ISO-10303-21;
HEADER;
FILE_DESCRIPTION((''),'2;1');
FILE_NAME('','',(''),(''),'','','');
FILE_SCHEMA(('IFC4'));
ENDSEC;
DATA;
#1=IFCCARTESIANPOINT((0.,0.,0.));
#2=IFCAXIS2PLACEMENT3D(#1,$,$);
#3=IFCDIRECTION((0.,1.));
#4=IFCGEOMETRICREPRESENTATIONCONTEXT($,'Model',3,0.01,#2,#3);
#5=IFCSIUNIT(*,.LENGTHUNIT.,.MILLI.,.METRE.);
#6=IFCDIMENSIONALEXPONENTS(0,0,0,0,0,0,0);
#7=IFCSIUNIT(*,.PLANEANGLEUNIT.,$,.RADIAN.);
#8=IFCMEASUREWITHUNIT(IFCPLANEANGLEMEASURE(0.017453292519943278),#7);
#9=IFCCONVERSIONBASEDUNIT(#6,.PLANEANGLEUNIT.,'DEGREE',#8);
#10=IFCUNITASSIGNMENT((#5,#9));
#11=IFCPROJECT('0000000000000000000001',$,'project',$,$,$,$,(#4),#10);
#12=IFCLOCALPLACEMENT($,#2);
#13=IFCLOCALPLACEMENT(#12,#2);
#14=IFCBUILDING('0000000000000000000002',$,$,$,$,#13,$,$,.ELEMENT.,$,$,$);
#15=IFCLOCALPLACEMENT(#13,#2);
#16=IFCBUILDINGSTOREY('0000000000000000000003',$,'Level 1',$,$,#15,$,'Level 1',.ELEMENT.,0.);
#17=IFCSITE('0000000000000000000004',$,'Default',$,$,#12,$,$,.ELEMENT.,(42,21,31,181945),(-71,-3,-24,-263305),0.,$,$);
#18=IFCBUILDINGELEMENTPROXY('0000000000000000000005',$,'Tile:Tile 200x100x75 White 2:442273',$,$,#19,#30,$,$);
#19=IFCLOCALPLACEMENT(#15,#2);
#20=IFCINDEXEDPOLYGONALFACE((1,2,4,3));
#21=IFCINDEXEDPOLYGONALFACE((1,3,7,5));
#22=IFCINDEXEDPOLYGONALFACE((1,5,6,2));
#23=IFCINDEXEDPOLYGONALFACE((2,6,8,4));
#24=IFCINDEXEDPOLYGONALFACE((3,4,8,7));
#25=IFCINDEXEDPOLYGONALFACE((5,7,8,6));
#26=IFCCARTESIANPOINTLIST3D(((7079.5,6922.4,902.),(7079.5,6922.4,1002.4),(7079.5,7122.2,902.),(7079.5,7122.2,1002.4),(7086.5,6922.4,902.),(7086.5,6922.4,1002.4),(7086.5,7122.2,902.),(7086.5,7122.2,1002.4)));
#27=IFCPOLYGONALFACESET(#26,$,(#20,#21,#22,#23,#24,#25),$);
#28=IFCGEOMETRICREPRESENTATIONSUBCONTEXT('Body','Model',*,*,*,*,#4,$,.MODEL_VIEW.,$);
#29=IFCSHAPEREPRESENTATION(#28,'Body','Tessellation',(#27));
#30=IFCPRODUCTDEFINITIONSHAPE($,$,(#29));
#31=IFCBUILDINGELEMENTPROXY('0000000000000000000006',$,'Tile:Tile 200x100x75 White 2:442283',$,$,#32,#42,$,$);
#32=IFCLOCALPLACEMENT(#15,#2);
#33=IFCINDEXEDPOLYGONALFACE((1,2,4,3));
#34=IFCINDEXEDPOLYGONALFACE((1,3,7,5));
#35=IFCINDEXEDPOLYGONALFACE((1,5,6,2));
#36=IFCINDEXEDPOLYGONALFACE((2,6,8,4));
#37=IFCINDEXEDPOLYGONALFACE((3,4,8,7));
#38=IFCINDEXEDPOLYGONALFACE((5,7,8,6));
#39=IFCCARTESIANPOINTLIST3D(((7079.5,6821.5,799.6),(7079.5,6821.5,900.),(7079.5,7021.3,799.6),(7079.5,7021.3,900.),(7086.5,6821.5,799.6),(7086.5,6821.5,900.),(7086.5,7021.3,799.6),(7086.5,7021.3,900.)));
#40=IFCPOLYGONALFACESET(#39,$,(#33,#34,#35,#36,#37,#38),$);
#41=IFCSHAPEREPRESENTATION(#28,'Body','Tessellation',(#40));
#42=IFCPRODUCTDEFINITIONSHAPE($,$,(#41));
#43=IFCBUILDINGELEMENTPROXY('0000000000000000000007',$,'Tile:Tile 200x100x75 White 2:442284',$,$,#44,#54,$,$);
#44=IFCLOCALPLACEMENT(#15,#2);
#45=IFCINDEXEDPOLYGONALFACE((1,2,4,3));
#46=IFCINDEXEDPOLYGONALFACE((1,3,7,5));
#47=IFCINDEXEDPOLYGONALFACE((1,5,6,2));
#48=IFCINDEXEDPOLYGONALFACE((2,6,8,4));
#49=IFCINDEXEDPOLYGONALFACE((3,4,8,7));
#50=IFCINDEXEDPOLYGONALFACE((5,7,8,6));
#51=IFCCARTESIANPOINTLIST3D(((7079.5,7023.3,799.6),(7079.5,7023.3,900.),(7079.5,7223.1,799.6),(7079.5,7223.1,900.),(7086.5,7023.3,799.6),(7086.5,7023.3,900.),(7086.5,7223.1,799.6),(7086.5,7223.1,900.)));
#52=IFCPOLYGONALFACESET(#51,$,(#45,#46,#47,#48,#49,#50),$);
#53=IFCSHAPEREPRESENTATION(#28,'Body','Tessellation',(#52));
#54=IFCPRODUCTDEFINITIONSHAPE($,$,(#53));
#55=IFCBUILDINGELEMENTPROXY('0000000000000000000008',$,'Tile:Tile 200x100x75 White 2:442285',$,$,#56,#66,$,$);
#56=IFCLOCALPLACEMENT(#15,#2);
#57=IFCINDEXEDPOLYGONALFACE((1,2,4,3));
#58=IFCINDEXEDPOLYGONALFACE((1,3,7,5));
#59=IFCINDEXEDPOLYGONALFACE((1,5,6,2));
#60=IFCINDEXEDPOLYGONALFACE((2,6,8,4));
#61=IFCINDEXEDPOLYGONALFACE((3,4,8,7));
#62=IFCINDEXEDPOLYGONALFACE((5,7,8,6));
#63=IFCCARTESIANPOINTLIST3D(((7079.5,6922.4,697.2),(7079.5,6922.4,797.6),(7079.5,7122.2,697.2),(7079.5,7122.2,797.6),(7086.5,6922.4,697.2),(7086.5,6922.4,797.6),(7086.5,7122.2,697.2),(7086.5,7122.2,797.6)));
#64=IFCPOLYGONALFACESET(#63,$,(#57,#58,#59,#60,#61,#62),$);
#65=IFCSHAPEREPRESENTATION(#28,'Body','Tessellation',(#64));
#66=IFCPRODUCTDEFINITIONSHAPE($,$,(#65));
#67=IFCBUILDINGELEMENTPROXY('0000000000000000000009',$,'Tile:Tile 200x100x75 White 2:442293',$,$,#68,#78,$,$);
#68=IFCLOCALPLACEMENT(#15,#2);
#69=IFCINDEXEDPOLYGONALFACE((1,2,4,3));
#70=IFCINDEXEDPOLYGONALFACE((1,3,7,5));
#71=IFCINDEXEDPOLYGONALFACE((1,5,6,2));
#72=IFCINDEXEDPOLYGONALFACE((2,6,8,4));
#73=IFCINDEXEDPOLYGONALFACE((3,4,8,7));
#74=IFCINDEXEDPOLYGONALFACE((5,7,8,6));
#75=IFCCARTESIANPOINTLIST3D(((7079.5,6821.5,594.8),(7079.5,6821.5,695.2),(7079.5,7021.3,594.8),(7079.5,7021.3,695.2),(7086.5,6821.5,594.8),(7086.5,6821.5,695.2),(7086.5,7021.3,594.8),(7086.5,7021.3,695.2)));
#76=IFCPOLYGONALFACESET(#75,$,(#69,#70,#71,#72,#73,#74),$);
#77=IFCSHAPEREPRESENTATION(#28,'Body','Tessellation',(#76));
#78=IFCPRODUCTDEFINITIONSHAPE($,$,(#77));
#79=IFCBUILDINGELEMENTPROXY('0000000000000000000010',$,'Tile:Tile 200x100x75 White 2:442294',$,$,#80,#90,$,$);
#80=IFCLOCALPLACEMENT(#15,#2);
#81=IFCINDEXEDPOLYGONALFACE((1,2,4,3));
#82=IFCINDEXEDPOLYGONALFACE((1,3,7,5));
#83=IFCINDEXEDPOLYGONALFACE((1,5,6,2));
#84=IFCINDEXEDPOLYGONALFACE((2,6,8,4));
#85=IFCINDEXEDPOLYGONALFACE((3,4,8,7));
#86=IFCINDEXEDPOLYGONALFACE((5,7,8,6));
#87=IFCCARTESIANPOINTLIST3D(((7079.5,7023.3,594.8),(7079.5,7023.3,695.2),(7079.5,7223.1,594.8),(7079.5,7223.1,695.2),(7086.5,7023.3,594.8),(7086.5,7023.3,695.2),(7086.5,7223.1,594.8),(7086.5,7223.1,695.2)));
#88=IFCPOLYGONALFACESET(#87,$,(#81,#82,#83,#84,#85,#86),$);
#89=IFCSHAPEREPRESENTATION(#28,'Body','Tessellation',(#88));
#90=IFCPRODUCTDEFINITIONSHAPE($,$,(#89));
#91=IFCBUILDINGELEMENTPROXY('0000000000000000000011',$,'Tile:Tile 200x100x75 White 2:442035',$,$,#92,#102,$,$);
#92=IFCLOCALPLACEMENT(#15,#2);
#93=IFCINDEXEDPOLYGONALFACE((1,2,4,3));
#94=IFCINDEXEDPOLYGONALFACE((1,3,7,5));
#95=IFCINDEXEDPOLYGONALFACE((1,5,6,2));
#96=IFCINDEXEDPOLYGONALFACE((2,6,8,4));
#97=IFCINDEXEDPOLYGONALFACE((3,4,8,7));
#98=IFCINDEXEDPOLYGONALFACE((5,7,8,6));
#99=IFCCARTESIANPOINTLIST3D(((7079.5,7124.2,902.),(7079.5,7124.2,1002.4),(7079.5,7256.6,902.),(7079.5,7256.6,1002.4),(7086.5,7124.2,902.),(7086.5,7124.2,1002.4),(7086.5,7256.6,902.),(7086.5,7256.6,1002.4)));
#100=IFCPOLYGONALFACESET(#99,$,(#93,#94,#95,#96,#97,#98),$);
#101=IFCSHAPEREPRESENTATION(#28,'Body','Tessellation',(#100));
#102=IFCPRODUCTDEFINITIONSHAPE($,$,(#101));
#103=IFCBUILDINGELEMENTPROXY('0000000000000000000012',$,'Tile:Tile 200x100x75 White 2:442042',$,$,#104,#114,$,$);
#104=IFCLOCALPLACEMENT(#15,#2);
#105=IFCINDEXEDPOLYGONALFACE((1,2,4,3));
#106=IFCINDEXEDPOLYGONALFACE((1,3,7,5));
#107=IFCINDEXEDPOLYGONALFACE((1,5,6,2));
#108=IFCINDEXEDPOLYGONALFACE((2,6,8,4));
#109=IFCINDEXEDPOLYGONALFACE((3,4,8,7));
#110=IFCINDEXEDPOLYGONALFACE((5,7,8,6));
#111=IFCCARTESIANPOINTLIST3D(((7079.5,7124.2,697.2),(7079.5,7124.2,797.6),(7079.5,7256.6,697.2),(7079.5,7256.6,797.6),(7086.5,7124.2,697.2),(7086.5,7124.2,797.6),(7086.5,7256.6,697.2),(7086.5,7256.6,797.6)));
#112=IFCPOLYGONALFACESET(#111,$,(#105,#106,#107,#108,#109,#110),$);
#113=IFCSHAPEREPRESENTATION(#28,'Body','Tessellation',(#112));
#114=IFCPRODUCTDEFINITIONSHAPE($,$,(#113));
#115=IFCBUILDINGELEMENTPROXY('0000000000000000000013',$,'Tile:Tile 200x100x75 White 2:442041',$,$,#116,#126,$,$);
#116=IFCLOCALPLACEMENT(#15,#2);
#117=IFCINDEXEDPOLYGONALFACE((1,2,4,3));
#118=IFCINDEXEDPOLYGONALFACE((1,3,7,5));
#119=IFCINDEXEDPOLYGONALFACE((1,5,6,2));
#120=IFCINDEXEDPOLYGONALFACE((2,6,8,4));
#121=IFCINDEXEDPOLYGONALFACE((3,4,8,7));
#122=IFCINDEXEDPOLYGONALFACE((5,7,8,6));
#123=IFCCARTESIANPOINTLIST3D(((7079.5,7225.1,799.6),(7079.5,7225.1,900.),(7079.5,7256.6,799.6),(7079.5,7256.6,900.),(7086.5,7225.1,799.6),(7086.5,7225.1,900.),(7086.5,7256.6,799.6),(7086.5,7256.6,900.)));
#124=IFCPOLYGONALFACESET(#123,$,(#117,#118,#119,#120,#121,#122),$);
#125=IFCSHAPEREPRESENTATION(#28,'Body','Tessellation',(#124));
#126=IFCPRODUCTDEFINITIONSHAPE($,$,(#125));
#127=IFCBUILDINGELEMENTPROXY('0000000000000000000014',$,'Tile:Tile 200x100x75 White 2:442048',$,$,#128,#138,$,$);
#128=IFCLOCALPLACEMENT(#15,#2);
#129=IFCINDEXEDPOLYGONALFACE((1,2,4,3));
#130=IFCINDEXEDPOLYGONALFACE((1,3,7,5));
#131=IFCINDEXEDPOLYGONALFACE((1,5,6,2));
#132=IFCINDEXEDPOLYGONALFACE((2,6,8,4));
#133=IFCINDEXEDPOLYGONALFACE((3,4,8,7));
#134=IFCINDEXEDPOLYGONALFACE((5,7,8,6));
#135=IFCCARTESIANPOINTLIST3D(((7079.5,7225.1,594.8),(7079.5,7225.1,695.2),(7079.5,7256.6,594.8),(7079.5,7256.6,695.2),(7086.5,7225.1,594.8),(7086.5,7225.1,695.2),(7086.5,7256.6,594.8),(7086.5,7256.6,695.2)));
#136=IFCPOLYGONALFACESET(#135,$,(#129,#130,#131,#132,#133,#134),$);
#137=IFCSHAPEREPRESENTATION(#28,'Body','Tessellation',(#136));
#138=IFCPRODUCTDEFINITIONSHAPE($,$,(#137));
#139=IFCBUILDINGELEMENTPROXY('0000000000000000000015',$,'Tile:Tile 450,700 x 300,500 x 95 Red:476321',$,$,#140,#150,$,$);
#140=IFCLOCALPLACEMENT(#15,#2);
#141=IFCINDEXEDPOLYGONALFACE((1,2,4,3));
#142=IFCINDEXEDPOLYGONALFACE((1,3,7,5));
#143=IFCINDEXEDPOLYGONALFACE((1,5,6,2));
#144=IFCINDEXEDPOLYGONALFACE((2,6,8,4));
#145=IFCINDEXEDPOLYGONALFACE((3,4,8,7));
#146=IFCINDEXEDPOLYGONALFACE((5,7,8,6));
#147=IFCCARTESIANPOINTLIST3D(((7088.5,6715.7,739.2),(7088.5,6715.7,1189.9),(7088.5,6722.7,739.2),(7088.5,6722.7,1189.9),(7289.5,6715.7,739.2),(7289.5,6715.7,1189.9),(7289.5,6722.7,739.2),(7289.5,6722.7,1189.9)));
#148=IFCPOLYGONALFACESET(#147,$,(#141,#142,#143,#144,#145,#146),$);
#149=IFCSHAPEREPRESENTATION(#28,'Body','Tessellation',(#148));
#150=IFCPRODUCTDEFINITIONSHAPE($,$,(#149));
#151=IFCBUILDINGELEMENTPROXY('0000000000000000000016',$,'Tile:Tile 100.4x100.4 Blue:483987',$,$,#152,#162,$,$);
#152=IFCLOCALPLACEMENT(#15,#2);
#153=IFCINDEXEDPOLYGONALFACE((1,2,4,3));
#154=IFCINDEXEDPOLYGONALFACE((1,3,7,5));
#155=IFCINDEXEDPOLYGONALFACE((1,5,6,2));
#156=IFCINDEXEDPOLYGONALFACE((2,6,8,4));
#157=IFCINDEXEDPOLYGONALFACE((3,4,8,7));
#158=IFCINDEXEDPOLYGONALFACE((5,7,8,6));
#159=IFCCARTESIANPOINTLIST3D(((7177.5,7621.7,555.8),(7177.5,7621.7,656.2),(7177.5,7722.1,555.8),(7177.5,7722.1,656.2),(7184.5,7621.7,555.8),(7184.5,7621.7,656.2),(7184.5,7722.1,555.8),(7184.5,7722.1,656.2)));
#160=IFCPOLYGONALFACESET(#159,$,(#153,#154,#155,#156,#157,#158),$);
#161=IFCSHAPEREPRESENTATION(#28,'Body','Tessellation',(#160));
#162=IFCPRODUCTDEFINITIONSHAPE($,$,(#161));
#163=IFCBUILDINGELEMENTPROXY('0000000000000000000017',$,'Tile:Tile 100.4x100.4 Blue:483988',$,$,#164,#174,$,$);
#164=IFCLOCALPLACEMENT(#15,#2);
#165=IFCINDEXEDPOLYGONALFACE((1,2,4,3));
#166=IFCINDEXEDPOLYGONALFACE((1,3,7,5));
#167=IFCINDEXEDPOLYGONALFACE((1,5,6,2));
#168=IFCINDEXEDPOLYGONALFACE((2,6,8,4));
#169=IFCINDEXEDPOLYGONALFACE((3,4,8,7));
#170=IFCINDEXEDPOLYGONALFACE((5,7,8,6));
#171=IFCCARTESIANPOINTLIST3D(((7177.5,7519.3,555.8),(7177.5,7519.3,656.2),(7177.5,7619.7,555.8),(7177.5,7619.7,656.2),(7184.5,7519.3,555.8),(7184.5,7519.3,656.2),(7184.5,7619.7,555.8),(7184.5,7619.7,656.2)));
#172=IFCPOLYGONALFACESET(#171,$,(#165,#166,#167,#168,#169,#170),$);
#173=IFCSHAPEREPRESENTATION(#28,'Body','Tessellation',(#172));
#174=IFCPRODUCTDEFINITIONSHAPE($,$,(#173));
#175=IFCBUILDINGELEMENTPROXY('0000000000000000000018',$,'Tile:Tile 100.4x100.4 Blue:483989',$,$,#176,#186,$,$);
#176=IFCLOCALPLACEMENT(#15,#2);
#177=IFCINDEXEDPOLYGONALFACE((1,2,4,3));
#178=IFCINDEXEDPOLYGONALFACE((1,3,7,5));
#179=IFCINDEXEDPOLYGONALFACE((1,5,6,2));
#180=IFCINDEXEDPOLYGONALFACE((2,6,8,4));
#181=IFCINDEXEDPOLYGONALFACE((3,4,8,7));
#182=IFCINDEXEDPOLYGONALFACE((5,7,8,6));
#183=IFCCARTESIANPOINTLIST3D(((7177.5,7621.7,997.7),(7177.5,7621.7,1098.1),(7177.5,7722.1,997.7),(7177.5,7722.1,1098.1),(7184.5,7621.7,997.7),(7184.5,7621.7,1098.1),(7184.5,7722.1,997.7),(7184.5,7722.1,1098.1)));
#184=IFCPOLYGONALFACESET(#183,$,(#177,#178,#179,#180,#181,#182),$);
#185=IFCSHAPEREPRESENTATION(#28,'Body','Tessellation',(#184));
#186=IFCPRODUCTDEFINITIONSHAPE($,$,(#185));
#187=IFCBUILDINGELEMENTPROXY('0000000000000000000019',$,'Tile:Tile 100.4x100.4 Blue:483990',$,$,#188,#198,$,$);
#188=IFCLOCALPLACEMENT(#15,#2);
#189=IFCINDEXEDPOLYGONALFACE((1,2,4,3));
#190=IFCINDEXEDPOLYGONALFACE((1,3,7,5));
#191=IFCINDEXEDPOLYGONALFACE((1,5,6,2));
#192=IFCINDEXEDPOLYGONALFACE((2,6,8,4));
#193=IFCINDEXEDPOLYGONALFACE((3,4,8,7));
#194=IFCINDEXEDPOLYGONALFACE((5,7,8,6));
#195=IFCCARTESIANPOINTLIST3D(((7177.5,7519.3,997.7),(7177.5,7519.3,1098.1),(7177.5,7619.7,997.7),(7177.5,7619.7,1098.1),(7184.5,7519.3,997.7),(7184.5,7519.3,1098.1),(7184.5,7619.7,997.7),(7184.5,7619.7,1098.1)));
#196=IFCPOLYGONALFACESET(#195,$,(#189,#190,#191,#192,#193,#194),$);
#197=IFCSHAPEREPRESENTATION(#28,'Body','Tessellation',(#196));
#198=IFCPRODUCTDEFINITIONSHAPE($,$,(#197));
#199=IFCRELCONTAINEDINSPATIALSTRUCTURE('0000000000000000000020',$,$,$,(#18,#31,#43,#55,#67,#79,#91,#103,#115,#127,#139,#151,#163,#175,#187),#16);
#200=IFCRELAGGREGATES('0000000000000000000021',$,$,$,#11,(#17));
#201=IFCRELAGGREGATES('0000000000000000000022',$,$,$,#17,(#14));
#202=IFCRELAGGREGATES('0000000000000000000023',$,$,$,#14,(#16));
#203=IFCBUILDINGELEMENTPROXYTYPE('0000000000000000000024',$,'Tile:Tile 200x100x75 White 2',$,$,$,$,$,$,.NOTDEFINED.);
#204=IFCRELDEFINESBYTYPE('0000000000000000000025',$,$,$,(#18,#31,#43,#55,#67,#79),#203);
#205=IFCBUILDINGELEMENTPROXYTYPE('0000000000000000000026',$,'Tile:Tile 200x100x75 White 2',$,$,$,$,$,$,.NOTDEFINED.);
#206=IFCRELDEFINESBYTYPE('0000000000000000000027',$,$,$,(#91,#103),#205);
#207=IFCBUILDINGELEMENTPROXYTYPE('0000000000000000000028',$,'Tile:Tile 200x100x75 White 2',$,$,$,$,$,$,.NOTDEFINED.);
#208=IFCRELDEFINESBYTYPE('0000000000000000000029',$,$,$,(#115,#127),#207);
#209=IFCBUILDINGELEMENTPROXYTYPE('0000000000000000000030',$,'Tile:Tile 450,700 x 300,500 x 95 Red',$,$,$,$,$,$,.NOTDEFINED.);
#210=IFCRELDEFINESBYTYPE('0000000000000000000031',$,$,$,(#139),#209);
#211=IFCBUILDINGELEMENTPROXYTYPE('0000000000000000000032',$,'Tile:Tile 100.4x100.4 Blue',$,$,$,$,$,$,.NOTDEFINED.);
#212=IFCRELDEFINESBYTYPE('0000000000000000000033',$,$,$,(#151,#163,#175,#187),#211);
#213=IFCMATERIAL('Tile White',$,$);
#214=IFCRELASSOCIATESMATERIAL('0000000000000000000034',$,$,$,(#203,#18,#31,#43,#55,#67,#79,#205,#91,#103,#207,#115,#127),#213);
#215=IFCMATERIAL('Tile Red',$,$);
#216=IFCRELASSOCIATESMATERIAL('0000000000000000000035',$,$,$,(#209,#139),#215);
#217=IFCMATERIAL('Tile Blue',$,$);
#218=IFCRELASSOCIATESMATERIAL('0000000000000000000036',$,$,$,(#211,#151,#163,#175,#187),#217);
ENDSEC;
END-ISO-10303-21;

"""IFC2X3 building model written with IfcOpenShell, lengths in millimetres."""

from ifc_helpers import new_model, entity, si_unit, converted_unit, direction, frame, frame_2d, origin, origin_2d_with_axis, place, context, subcontext, project, spatial, rectangle, extrude, source, transform, mapped, material, type_object, type_shapes, element, save


model = new_model("IFC2X3")

# Units and contexts
model_context = context("Model", 3, precision=0.01, world=origin(), true_north=direction((0.0, 1.0)))
body_context = subcontext(model_context, "Body", "Model", "MODEL_VIEW")
ifc_project = project(units=[si_unit("LENGTHUNIT", "METRE", prefix="MILLI"), converted_unit("PLANEANGLEUNIT", "DEGREE", entity("IfcPlaneAngleMeasure", 0.017453292519943278), si_unit("PLANEANGLEUNIT", "RADIAN"), dimensions=[0, 0, 0, 0, 0, 0, 0])], contexts=[model_context])

# Site, building, storey
site_placement = place(None, origin())
site = spatial("IfcSite", under=ifc_project, at=site_placement, Name="Default", CompositionType="ELEMENT", RefLatitude=(42, 21, 31, 181945), RefLongitude=(-71, -3, -24, -263305), RefElevation=0.0)
building_placement = place(site_placement, origin())
building = spatial("IfcBuilding", under=site, at=building_placement, CompositionType="ELEMENT")
storey_placement = place(building_placement, origin())
storey = spatial("IfcBuildingStorey", under=building, at=storey_placement, Name="Level 1", LongName="Level 1", CompositionType="ELEMENT", Elevation=0.0)

# Building element proxies
ifc_material_1 = material(Name="Tile White")
building_element_proxy_type_1 = type_object("IfcBuildingElementProxyType", Name="Tile:Tile 200x100x75 White 2", PredefinedType="NOTDEFINED", material=ifc_material_1)
shared_shape_1 = source(origin(), body_context, "Body", "SweptSolid", [
    extrude(rectangle(XDim=199.8, YDim=100.4, at=frame_2d((0.0, 0.0), x_axis=(1.0, 0.0))), frame((-50.2, -99.9, 0.0), z_axis=(0.0, 0.0, 1.0), x_axis=(0.0, -1.0, 0.0)), (0.0, 0.0, 1.0), 7.0),
])
type_shapes(building_element_proxy_type_1, [shared_shape_1])
for number, where, z_axis, x_axis, name in (
    (1, (7086.5, 7122.2, 1002.4), (-1.0, 0.0, 0.0), (0.0, 0.0, 1.0), "Tile:Tile 200x100x75 White 2:442273"),
    (2, (7086.5, 7021.3, 900.0), (-1.0, 0.0, 0.0), (0.0, 0.0, 1.0), "Tile:Tile 200x100x75 White 2:442283"),
    (3, (7086.5, 7223.1, 900.0), (-1.0, 0.0, 0.0), (0.0, 0.0, 1.0), "Tile:Tile 200x100x75 White 2:442284"),
    (4, (7086.5, 7122.2, 797.6), (-1.0, 0.0, 0.0), (0.0, 0.0, 1.0), "Tile:Tile 200x100x75 White 2:442285"),
    (5, (7086.5, 7021.3, 695.2), (-1.0, 0.0, 0.0), (0.0, 0.0, 1.0), "Tile:Tile 200x100x75 White 2:442293"),
    (6, (7086.5, 7223.1, 695.2), (-1.0, 0.0, 0.0), (0.0, 0.0, 1.0), "Tile:Tile 200x100x75 White 2:442294"),
):
    element("IfcBuildingElementProxy", number, at=place(storey_placement, frame(where, z_axis=z_axis, x_axis=x_axis)), inside=storey, type_object=building_element_proxy_type_1, material=ifc_material_1, Name=name, context=body_context, shape_type="MappedRepresentation", body=[
        mapped(shared_shape_1, transform((0.0, 0.0, 0.0), scale=1.0)),
    ])
building_element_proxy_type_2 = type_object("IfcBuildingElementProxyType", Name="Tile:Tile 200x100x75 White 2", PredefinedType="NOTDEFINED", material=ifc_material_1)
shared_shape_2 = source(origin(), body_context, "Body", "SweptSolid", [
    extrude(rectangle(XDim=100.4, YDim=132.4, at=frame_2d((0.0, 0.0), x_axis=(1.0, 0.0))), frame((-50.2, 66.2, 0.0)), (0.0, 0.0, 1.0), 7.0),
])
type_shapes(building_element_proxy_type_2, [shared_shape_2])
for number, where, z_axis, x_axis, name in (
    (7, (7086.5, 7124.2, 1002.4), (-1.0, 0.0, 0.0), (0.0, 0.0, 1.0), "Tile:Tile 200x100x75 White 2:442035"),
    (8, (7086.5, 7124.2, 797.6), (-1.0, 0.0, 0.0), (0.0, 0.0, 1.0), "Tile:Tile 200x100x75 White 2:442042"),
):
    element("IfcBuildingElementProxy", number, at=place(storey_placement, frame(where, z_axis=z_axis, x_axis=x_axis)), inside=storey, type_object=building_element_proxy_type_2, material=ifc_material_1, Name=name, context=body_context, shape_type="MappedRepresentation", body=[
        mapped(shared_shape_2, transform((0.0, 0.0, 0.0), scale=1.0)),
    ])
building_element_proxy_type_3 = type_object("IfcBuildingElementProxyType", Name="Tile:Tile 200x100x75 White 2", PredefinedType="NOTDEFINED", material=ifc_material_1)
shared_shape_3 = source(origin(), body_context, "Body", "SweptSolid", [
    extrude(rectangle(XDim=100.4, YDim=31.5, at=origin_2d_with_axis()), frame((-50.2, 15.8, 0.0)), (0.0, 0.0, 1.0), 7.0),
])
type_shapes(building_element_proxy_type_3, [shared_shape_3])
for number, where, z_axis, x_axis, name in (
    (9, (7086.5, 7225.1, 900.0), (-1.0, 0.0, 0.0), (0.0, 0.0, 1.0), "Tile:Tile 200x100x75 White 2:442041"),
    (10, (7086.5, 7225.1, 695.2), (-1.0, 0.0, 0.0), (0.0, 0.0, 1.0), "Tile:Tile 200x100x75 White 2:442048"),
):
    element("IfcBuildingElementProxy", number, at=place(storey_placement, frame(where, z_axis=z_axis, x_axis=x_axis)), inside=storey, type_object=building_element_proxy_type_3, material=ifc_material_1, Name=name, context=body_context, shape_type="MappedRepresentation", body=[
        mapped(shared_shape_3, transform((0.0, 0.0, 0.0), scale=1.0)),
    ])
ifc_material_2 = material(Name="Tile Red")
building_element_proxy_type_4 = type_object("IfcBuildingElementProxyType", Name="Tile:Tile 450,700 x 300,500 x 95 Red", PredefinedType="NOTDEFINED", material=ifc_material_2)
shared_shape_4 = source(origin(), body_context, "Body", "SweptSolid", [
    extrude(rectangle(XDim=201.0, YDim=450.7, at=frame_2d((0.0, 0.0), x_axis=(1.0, 0.0))), frame((-100.5, -225.4, 0.0), z_axis=(0.0, 0.0, 1.0), x_axis=(-1.0, 0.0, 0.0)), (0.0, 0.0, 1.0), 7.0),
])
type_shapes(building_element_proxy_type_4, [shared_shape_4])
proxy_placement = place(storey_placement, frame((7088.5, 6722.7, 739.2), z_axis=(0.0, -1.0, 0.0), x_axis=(-1.0, 0.0, 0.0)))
element("IfcBuildingElementProxy", 11, at=proxy_placement, inside=storey, type_object=building_element_proxy_type_4, material=ifc_material_2, Name="Tile:Tile 450,700 x 300,500 x 95 Red:476321", context=body_context, shape_type="MappedRepresentation", body=[
    mapped(shared_shape_4, transform((0.0, 0.0, 0.0), scale=1.0)),
])
ifc_material_3 = material(Name="Tile Blue")
building_element_proxy_type_5 = type_object("IfcBuildingElementProxyType", Name="Tile:Tile 100.4x100.4 Blue", PredefinedType="NOTDEFINED", material=ifc_material_3)
shared_shape_5 = source(origin(), body_context, "Body", "SweptSolid", [
    extrude(rectangle(XDim=100.4, YDim=100.4, at=origin_2d_with_axis()), frame((-50.2, -50.2, 0.0), z_axis=(0.0, 0.0, 1.0), x_axis=(0.0, -1.0, 0.0)), (0.0, 0.0, 1.0), 7.0),
])
type_shapes(building_element_proxy_type_5, [shared_shape_5])
for number, where, z_axis, x_axis, name in (
    (12, (7184.5, 7722.1, 555.8), (-1.0, 0.0, 0.0), (0.0, 1.0, 0.0), "Tile:Tile 100.4x100.4 Blue:483987"),
    (13, (7184.5, 7619.7, 555.8), (-1.0, 0.0, 0.0), (0.0, 1.0, 0.0), "Tile:Tile 100.4x100.4 Blue:483988"),
    (14, (7184.5, 7722.1, 997.7), (-1.0, 0.0, 0.0), (0.0, 1.0, 0.0), "Tile:Tile 100.4x100.4 Blue:483989"),
    (15, (7184.5, 7619.7, 997.7), (-1.0, 0.0, 0.0), (0.0, 1.0, 0.0), "Tile:Tile 100.4x100.4 Blue:483990"),
):
    element("IfcBuildingElementProxy", number, at=place(storey_placement, frame(where, z_axis=z_axis, x_axis=x_axis)), inside=storey, type_object=building_element_proxy_type_5, material=ifc_material_3, Name=name, context=body_context, shape_type="MappedRepresentation", body=[
        mapped(shared_shape_5, transform((0.0, 0.0, 0.0), scale=1.0)),
    ])

save(model, "model.ifc")
